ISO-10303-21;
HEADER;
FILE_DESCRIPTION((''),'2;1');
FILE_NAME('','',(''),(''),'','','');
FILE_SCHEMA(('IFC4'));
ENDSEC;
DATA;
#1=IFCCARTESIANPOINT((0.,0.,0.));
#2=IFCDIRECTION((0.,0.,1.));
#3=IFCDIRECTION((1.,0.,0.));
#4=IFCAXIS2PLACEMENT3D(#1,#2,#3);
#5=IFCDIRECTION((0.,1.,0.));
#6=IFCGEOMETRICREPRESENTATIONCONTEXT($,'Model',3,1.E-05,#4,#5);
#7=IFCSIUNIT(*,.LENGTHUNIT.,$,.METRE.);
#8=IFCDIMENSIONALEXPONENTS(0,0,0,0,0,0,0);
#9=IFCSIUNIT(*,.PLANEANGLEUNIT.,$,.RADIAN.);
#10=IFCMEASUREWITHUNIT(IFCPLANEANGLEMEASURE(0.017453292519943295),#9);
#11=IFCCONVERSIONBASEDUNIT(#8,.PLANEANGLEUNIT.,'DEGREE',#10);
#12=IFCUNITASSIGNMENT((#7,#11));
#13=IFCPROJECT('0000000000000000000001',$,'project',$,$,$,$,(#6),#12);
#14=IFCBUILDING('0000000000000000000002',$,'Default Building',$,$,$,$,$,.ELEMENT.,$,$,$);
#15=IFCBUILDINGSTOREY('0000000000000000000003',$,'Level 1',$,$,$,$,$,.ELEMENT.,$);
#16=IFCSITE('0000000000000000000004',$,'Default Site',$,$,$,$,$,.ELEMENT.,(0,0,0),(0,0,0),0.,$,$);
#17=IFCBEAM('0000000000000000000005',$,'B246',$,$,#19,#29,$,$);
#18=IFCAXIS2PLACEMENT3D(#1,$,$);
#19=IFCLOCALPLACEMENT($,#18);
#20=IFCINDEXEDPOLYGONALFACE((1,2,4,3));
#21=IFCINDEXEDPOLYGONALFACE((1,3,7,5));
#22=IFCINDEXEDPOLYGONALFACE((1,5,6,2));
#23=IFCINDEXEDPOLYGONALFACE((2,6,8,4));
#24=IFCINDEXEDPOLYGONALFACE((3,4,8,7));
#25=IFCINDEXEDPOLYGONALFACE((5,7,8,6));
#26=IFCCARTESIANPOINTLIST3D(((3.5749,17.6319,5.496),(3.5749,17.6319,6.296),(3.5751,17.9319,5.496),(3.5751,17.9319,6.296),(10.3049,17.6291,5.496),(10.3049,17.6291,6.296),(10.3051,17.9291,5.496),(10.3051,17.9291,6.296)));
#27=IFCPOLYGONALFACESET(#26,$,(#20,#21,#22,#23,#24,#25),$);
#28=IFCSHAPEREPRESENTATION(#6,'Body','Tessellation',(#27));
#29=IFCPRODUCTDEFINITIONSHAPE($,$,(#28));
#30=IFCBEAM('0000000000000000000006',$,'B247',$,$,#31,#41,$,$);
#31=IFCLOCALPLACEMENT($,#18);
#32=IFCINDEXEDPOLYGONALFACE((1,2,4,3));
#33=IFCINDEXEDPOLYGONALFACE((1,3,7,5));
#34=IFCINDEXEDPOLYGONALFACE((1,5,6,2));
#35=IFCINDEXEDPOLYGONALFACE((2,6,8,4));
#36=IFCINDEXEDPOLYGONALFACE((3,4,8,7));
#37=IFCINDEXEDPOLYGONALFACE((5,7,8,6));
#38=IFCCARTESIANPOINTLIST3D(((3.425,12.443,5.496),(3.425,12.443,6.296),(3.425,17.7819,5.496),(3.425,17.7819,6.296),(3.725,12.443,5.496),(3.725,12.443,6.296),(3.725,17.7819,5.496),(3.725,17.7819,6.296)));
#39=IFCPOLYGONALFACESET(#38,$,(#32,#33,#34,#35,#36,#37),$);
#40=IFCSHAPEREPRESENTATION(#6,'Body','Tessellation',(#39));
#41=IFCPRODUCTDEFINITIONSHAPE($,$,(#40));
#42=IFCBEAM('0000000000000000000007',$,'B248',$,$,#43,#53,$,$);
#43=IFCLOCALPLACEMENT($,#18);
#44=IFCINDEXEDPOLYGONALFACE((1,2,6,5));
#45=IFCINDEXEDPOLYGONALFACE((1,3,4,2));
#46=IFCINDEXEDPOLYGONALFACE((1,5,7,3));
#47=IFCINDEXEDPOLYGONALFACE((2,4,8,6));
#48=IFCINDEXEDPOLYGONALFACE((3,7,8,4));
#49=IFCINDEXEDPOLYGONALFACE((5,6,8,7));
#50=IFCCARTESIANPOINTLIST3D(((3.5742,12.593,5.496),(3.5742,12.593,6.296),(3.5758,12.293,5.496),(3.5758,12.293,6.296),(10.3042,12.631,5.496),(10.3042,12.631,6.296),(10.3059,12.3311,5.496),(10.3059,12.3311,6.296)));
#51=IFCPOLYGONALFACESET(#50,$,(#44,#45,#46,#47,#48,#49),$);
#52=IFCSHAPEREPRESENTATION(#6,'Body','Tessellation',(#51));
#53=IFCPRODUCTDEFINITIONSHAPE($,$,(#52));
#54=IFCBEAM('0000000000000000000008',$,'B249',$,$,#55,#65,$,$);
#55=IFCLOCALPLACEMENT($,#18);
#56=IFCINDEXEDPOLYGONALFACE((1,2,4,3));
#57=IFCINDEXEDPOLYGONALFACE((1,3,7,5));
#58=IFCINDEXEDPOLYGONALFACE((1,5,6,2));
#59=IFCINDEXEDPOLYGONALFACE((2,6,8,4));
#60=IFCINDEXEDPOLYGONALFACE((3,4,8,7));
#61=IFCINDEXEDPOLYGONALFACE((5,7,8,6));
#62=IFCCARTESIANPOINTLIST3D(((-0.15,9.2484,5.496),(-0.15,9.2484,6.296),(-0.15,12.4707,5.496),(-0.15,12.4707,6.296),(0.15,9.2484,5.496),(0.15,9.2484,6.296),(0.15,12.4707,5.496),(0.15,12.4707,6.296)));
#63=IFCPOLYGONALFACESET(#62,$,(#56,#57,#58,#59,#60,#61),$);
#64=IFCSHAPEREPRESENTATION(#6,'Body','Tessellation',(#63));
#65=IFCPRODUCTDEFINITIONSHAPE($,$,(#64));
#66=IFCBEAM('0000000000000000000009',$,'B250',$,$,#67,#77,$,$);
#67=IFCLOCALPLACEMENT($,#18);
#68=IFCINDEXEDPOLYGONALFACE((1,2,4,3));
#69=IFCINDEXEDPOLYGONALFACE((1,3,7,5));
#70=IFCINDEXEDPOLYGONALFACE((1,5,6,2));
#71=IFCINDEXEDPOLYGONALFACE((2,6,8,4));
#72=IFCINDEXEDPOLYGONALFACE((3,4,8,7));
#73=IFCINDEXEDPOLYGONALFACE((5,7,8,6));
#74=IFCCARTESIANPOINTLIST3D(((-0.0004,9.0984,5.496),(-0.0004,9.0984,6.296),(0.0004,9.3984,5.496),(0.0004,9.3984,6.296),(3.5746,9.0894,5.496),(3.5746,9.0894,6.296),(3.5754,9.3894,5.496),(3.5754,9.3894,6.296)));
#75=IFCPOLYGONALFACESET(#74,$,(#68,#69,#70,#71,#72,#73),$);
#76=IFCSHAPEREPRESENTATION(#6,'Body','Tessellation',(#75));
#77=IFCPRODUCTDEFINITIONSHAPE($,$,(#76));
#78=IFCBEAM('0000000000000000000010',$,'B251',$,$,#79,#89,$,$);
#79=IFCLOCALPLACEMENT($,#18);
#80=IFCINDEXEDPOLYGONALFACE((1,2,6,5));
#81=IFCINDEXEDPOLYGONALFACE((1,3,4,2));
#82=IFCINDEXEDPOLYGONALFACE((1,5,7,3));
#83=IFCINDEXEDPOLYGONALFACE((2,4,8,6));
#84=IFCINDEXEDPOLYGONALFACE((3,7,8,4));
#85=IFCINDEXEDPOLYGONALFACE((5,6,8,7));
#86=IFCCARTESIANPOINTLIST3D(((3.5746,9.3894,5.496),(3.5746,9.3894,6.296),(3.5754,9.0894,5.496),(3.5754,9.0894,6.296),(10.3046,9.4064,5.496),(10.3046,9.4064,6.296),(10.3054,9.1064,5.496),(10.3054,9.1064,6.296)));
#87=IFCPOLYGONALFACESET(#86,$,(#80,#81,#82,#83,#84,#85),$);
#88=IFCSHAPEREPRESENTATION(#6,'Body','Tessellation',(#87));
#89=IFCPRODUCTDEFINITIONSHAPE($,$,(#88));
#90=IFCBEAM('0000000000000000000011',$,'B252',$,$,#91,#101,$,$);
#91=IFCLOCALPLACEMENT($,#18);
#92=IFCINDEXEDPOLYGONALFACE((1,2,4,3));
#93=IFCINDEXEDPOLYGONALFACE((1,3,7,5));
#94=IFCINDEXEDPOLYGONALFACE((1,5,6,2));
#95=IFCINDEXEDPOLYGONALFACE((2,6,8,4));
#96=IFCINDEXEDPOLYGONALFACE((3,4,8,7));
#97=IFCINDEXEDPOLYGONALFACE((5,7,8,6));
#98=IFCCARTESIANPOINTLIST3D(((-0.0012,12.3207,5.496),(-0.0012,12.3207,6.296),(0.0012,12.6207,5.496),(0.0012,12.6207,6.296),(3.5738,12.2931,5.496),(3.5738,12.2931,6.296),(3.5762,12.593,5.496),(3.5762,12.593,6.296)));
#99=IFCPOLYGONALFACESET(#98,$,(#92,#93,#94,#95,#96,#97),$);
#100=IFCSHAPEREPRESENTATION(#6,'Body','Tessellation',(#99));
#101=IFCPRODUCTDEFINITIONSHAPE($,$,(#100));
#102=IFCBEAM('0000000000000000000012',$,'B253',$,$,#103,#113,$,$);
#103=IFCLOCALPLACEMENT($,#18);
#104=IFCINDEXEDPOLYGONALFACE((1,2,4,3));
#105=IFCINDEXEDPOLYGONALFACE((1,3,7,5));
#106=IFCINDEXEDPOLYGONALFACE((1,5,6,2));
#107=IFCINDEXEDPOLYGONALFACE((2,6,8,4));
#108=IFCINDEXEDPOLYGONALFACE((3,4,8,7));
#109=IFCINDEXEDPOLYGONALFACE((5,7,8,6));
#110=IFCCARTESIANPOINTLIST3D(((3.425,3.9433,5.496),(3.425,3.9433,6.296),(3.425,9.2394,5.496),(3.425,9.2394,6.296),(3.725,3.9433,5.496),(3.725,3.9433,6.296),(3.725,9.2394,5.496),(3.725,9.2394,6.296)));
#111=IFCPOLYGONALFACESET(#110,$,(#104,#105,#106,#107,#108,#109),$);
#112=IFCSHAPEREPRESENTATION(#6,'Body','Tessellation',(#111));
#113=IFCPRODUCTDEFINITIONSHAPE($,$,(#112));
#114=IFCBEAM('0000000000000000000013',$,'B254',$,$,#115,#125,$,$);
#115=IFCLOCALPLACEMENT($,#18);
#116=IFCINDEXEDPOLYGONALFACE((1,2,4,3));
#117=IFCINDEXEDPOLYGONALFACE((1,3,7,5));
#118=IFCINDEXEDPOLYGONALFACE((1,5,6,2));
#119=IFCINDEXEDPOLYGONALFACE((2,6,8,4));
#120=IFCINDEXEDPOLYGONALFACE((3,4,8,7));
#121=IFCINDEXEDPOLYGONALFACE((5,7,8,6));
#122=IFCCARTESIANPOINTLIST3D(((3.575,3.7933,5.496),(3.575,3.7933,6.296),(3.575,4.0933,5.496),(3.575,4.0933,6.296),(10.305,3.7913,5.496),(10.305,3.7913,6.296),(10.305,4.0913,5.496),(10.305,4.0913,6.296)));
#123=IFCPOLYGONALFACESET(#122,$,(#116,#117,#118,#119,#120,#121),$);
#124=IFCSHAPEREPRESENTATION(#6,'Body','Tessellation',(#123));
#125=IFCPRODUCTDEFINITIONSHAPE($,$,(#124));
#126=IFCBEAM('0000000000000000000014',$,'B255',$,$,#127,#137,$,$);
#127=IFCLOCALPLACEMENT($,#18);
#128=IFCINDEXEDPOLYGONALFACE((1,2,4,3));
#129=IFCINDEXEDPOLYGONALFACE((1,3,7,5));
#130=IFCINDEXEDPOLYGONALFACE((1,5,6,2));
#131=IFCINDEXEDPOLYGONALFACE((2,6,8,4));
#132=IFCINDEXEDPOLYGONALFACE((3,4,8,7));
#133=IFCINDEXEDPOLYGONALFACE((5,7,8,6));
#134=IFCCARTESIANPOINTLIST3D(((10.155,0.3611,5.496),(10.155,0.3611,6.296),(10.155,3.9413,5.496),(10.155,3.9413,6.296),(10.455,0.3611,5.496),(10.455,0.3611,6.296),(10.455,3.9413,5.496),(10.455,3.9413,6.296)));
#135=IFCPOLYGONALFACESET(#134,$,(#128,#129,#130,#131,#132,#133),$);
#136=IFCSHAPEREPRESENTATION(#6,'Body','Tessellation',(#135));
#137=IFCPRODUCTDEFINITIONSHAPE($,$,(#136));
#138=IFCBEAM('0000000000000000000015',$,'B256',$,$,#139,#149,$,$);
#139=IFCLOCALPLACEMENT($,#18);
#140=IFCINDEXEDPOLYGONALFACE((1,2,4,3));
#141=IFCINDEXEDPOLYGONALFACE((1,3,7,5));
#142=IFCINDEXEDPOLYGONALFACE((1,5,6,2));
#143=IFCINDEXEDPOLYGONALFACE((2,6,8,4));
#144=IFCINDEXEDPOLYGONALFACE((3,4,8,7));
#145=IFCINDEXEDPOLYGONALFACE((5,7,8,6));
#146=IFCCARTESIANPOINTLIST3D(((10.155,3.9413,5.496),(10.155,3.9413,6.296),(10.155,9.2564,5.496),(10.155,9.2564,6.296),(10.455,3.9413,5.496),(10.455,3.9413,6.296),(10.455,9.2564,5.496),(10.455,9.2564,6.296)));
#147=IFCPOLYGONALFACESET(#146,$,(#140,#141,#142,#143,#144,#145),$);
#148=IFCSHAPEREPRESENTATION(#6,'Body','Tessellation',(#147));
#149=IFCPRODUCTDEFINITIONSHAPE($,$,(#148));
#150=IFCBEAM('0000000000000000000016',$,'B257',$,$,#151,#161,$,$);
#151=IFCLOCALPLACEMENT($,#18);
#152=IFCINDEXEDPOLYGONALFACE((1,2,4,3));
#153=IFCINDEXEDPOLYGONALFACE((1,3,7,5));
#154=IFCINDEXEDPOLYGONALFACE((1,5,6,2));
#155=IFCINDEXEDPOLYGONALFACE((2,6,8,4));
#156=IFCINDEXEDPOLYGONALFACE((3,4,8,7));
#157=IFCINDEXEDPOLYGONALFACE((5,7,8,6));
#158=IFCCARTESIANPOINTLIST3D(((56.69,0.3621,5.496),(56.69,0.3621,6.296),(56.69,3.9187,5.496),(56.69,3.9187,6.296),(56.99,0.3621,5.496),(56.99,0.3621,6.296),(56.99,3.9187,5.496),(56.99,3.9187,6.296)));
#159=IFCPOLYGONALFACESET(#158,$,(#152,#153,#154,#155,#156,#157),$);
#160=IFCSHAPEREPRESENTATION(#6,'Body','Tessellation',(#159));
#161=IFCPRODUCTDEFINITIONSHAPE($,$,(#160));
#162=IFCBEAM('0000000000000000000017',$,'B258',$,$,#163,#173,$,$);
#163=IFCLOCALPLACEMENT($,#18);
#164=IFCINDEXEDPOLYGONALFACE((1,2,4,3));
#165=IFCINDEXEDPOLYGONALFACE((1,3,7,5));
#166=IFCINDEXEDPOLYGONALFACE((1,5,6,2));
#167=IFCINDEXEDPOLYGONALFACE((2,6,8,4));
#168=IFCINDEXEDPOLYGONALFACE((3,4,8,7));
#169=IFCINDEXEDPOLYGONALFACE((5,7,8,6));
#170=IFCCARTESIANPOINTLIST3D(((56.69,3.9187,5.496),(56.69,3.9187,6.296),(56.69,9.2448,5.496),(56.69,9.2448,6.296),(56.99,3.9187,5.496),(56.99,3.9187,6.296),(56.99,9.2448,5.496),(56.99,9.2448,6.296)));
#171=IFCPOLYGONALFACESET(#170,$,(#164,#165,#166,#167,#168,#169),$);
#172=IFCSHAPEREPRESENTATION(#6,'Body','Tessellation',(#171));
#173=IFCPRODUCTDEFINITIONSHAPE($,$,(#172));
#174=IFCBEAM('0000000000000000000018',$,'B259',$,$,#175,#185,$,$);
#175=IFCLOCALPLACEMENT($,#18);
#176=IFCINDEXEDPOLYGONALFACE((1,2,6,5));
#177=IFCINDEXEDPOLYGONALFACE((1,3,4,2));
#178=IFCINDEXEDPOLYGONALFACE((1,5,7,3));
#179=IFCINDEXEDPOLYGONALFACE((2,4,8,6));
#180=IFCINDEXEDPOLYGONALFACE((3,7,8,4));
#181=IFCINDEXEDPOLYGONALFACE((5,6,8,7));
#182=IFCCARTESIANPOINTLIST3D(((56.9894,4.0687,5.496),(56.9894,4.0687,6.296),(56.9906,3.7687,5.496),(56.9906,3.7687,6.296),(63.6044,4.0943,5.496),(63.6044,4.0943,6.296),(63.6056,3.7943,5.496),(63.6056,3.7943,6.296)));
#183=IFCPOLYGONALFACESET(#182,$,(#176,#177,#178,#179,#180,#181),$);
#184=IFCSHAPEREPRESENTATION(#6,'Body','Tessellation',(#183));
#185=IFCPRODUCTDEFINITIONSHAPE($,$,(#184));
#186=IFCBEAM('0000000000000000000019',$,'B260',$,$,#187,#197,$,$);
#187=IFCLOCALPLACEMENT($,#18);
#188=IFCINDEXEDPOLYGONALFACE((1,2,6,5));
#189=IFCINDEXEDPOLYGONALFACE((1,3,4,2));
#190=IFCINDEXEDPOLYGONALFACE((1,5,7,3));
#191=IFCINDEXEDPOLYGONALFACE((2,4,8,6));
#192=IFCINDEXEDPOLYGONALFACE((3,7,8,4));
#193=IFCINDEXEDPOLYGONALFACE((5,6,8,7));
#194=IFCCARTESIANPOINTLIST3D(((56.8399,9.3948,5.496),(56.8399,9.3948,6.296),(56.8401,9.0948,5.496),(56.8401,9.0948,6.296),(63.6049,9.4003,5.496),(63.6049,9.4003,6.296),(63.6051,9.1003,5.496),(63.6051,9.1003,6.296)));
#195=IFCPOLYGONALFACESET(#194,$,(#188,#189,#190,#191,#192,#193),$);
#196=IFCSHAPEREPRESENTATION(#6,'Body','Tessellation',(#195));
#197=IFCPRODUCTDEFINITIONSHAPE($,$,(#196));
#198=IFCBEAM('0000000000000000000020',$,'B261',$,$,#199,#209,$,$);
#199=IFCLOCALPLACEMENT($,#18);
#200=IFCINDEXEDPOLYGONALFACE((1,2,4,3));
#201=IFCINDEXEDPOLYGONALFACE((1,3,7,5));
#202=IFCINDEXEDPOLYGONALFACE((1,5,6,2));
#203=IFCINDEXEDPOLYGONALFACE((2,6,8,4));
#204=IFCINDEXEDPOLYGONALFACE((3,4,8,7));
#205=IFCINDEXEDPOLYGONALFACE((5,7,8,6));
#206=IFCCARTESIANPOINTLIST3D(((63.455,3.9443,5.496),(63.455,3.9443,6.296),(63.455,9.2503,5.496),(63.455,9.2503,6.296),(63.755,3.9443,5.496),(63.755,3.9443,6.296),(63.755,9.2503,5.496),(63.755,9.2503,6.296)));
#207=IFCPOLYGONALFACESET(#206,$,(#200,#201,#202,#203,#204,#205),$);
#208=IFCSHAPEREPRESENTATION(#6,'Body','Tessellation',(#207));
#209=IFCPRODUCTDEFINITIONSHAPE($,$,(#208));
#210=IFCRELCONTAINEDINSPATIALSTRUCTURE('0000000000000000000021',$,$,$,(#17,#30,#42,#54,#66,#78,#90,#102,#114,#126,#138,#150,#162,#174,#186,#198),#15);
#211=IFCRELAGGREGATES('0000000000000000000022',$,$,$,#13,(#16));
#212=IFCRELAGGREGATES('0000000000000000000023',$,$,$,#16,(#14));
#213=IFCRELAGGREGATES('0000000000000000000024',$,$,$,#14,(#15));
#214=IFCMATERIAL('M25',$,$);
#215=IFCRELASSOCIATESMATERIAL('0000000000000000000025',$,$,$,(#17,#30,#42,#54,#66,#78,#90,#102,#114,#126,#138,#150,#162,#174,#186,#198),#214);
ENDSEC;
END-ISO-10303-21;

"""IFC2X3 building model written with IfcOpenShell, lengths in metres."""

from ifc_helpers import new_model, entity, si_unit, converted_unit, direction, frame, frame_2d, origin_with_axes, place, context, project, spatial, rectangle, extrude, material, element, save


model = new_model("IFC2X3")

# Units and contexts
model_context = context("Model", 3, precision=1e-05, world=origin_with_axes(), true_north=direction((0.0, 1.0, 0.0)))
ifc_project = project(units=[si_unit("LENGTHUNIT", "METRE"), converted_unit("PLANEANGLEUNIT", "DEGREE", entity("IfcPlaneAngleMeasure", 0.017453292519943295), si_unit("PLANEANGLEUNIT", "RADIAN"), dimensions=[0, 0, 0, 0, 0, 0, 0])], contexts=[model_context])

# Site, building, storey
site = spatial("IfcSite", under=ifc_project, Name="Default Site", CompositionType="ELEMENT", RefLatitude=(0, 0, 0), RefLongitude=(0, 0, 0), RefElevation=0.0)
building = spatial("IfcBuilding", under=site, Name="Default Building", CompositionType="ELEMENT")
storey = spatial("IfcBuildingStorey", under=building, Name="Level 1", CompositionType="ELEMENT")

# Beams
ifc_material = material(Name="M25")
placement = place(None, origin_with_axes())
element("IfcBeam", 1, at=placement, inside=storey, material=ifc_material, Name="B246", context=model_context, shape_type="SweptSolid", body=[
    extrude(rectangle(XDim=0.3, YDim=0.8, at=frame_2d((0.0, 0.0), x_axis=(0.0, 1.0, 0.0))), frame((10.305, 17.7791, 5.896), z_axis=(-1.0, 0.000419, 0.0), x_axis=(0.0, 0.0, -1.0)), (0.0, 0.0, 1.0), 6.73),
])
element("IfcBeam", 2, at=placement, inside=storey, material=ifc_material, Name="B247", context=model_context, shape_type="SweptSolid", body=[
    extrude(rectangle(XDim=0.3, YDim=0.8, at=frame_2d((0.0, 0.0), x_axis=(0.0, 1.0, 0.0))), frame((3.575, 12.443, 5.896), z_axis=(0.0, 1.0, 0.0), x_axis=(0.0, 0.0, -1.0)), (0.0, 0.0, 1.0), 5.3389),
])
element("IfcBeam", 3, at=placement, inside=storey, material=ifc_material, Name="B248", context=model_context, shape_type="SweptSolid", body=[
    extrude(rectangle(XDim=0.3, YDim=0.8, at=frame_2d((0.0, 0.0), x_axis=(0.0, 1.0, 0.0))), frame((3.575, 12.443, 5.896), z_axis=(0.999984, 0.005654, 0.0), x_axis=(0.0, 0.0, -1.0)), (0.0, 0.0, 1.0), 6.7301),
])
element("IfcBeam", 4, at=placement, inside=storey, material=ifc_material, Name="B249", context=model_context, shape_type="SweptSolid", body=[
    extrude(rectangle(XDim=0.3, YDim=0.8, at=frame_2d((0.0, 0.0), x_axis=(0.0, 1.0, 0.0))), frame((0.0, 9.2484, 5.896), z_axis=(0.0, 1.0, 0.0), x_axis=(0.0, 0.0, -1.0)), (0.0, 0.0, 1.0), 3.2223),
])
element("IfcBeam", 5, at=placement, inside=storey, material=ifc_material, Name="B250", context=model_context, shape_type="SweptSolid", body=[
    extrude(rectangle(XDim=0.3, YDim=0.8, at=frame_2d((0.0, 0.0), x_axis=(0.0, 1.0, 0.0))), frame((0.0, 9.2484, 5.896), z_axis=(0.999997, -0.002499, 0.0), x_axis=(0.0, 0.0, -1.0)), (0.0, 0.0, 1.0), 3.575),
])
element("IfcBeam", 6, at=placement, inside=storey, material=ifc_material, Name="B251", context=model_context, shape_type="SweptSolid", body=[
    extrude(rectangle(XDim=0.3, YDim=0.8, at=frame_2d((0.0, 0.0), x_axis=(0.0, 1.0, 0.0))), frame((3.575, 9.2394, 5.896), z_axis=(0.999997, 0.002522, 0.0), x_axis=(0.0, 0.0, -1.0)), (0.0, 0.0, 1.0), 6.73),
])
element("IfcBeam", 7, at=placement, inside=storey, material=ifc_material, Name="B252", context=model_context, shape_type="SweptSolid", body=[
    extrude(rectangle(XDim=0.3, YDim=0.8, at=frame_2d((0.0, 0.0), x_axis=(0.0, 1.0, 0.0))), frame((0.0, 12.4707, 5.896), z_axis=(0.99997, -0.007734, 0.0), x_axis=(0.0, 0.0, -1.0)), (0.0, 0.0, 1.0), 3.5751),
])
element("IfcBeam", 8, at=placement, inside=storey, material=ifc_material, Name="B253", context=model_context, shape_type="SweptSolid", body=[
    extrude(rectangle(XDim=0.3, YDim=0.8, at=frame_2d((0.0, 0.0), x_axis=(0.0, 1.0, 0.0))), frame((3.575, 3.9433, 5.896), z_axis=(0.0, 1.0, 0.0), x_axis=(0.0, 0.0, -1.0)), (0.0, 0.0, 1.0), 5.2961),
])
element("IfcBeam", 9, at=placement, inside=storey, material=ifc_material, Name="B254", context=model_context, shape_type="SweptSolid", body=[
    extrude(rectangle(XDim=0.3, YDim=0.8, at=frame_2d((0.0, 0.0), x_axis=(0.0, 1.0, 0.0))), frame((3.575, 3.9433, 5.896), z_axis=(1.0, -0.000302, 0.0), x_axis=(0.0, 0.0, -1.0)), (0.0, 0.0, 1.0), 6.73),
])
element("IfcBeam", 10, at=placement, inside=storey, material=ifc_material, Name="B255", context=model_context, shape_type="SweptSolid", body=[
    extrude(rectangle(XDim=0.3, YDim=0.8, at=frame_2d((0.0, 0.0), x_axis=(0.0, 1.0, 0.0))), frame((10.305, 3.9413, 5.896), z_axis=(0.0, -1.0, 0.0), x_axis=(0.0, 0.0, -1.0)), (0.0, 0.0, 1.0), 3.5802),
])
element("IfcBeam", 11, at=placement, inside=storey, material=ifc_material, Name="B256", context=model_context, shape_type="SweptSolid", body=[
    extrude(rectangle(XDim=0.3, YDim=0.8, at=frame_2d((0.0, 0.0), x_axis=(0.0, 1.0, 0.0))), frame((10.305, 3.9413, 5.896), z_axis=(0.0, 1.0, 0.0), x_axis=(0.0, 0.0, -1.0)), (0.0, 0.0, 1.0), 5.3151),
])
element("IfcBeam", 12, at=placement, inside=storey, material=ifc_material, Name="B257", context=model_context, shape_type="SweptSolid", body=[
    extrude(rectangle(XDim=0.3, YDim=0.8, at=frame_2d((0.0, 0.0), x_axis=(0.0, 1.0, 0.0))), frame((56.84, 0.3621, 5.896), z_axis=(0.0, 1.0, 0.0), x_axis=(0.0, 0.0, -1.0)), (0.0, 0.0, 1.0), 3.5566),
])
element("IfcBeam", 13, at=placement, inside=storey, material=ifc_material, Name="B258", context=model_context, shape_type="SweptSolid", body=[
    extrude(rectangle(XDim=0.3, YDim=0.8, at=frame_2d((0.0, 0.0), x_axis=(0.0, 1.0, 0.0))), frame((56.84, 3.9187, 5.896), z_axis=(0.0, 1.0, 0.0), x_axis=(0.0, 0.0, -1.0)), (0.0, 0.0, 1.0), 5.3261),
])
element("IfcBeam", 14, at=placement, inside=storey, material=ifc_material, Name="B259", context=model_context, shape_type="SweptSolid", body=[
    extrude(rectangle(XDim=0.3, YDim=0.8, at=frame_2d((0.0, 0.0), x_axis=(0.0, 1.0, 0.0))), frame((56.99, 3.9187, 5.896), z_axis=(0.999993, 0.003873, 0.0), x_axis=(0.0, 0.0, -1.0)), (0.0, 0.0, 1.0), 6.6151),
])
element("IfcBeam", 15, at=placement, inside=storey, material=ifc_material, Name="B260", context=model_context, shape_type="SweptSolid", body=[
    extrude(rectangle(XDim=0.3, YDim=0.8, at=frame_2d((0.0, 0.0), x_axis=(0.0, 1.0, 0.0))), frame((56.84, 9.2448, 5.896), z_axis=(1.0, 0.000816, 0.0), x_axis=(0.0, 0.0, -1.0)), (0.0, 0.0, 1.0), 6.765),
])
element("IfcBeam", 16, at=placement, inside=storey, material=ifc_material, Name="B261", context=model_context, shape_type="SweptSolid", body=[
    extrude(rectangle(XDim=0.3, YDim=0.8, at=frame_2d((0.0, 0.0), x_axis=(0.0, 1.0, 0.0))), frame((63.605, 3.9443, 5.896), z_axis=(0.0, 1.0, 0.0), x_axis=(0.0, 0.0, -1.0)), (0.0, 0.0, 1.0), 5.306),
])

save(model, "model.ifc")
